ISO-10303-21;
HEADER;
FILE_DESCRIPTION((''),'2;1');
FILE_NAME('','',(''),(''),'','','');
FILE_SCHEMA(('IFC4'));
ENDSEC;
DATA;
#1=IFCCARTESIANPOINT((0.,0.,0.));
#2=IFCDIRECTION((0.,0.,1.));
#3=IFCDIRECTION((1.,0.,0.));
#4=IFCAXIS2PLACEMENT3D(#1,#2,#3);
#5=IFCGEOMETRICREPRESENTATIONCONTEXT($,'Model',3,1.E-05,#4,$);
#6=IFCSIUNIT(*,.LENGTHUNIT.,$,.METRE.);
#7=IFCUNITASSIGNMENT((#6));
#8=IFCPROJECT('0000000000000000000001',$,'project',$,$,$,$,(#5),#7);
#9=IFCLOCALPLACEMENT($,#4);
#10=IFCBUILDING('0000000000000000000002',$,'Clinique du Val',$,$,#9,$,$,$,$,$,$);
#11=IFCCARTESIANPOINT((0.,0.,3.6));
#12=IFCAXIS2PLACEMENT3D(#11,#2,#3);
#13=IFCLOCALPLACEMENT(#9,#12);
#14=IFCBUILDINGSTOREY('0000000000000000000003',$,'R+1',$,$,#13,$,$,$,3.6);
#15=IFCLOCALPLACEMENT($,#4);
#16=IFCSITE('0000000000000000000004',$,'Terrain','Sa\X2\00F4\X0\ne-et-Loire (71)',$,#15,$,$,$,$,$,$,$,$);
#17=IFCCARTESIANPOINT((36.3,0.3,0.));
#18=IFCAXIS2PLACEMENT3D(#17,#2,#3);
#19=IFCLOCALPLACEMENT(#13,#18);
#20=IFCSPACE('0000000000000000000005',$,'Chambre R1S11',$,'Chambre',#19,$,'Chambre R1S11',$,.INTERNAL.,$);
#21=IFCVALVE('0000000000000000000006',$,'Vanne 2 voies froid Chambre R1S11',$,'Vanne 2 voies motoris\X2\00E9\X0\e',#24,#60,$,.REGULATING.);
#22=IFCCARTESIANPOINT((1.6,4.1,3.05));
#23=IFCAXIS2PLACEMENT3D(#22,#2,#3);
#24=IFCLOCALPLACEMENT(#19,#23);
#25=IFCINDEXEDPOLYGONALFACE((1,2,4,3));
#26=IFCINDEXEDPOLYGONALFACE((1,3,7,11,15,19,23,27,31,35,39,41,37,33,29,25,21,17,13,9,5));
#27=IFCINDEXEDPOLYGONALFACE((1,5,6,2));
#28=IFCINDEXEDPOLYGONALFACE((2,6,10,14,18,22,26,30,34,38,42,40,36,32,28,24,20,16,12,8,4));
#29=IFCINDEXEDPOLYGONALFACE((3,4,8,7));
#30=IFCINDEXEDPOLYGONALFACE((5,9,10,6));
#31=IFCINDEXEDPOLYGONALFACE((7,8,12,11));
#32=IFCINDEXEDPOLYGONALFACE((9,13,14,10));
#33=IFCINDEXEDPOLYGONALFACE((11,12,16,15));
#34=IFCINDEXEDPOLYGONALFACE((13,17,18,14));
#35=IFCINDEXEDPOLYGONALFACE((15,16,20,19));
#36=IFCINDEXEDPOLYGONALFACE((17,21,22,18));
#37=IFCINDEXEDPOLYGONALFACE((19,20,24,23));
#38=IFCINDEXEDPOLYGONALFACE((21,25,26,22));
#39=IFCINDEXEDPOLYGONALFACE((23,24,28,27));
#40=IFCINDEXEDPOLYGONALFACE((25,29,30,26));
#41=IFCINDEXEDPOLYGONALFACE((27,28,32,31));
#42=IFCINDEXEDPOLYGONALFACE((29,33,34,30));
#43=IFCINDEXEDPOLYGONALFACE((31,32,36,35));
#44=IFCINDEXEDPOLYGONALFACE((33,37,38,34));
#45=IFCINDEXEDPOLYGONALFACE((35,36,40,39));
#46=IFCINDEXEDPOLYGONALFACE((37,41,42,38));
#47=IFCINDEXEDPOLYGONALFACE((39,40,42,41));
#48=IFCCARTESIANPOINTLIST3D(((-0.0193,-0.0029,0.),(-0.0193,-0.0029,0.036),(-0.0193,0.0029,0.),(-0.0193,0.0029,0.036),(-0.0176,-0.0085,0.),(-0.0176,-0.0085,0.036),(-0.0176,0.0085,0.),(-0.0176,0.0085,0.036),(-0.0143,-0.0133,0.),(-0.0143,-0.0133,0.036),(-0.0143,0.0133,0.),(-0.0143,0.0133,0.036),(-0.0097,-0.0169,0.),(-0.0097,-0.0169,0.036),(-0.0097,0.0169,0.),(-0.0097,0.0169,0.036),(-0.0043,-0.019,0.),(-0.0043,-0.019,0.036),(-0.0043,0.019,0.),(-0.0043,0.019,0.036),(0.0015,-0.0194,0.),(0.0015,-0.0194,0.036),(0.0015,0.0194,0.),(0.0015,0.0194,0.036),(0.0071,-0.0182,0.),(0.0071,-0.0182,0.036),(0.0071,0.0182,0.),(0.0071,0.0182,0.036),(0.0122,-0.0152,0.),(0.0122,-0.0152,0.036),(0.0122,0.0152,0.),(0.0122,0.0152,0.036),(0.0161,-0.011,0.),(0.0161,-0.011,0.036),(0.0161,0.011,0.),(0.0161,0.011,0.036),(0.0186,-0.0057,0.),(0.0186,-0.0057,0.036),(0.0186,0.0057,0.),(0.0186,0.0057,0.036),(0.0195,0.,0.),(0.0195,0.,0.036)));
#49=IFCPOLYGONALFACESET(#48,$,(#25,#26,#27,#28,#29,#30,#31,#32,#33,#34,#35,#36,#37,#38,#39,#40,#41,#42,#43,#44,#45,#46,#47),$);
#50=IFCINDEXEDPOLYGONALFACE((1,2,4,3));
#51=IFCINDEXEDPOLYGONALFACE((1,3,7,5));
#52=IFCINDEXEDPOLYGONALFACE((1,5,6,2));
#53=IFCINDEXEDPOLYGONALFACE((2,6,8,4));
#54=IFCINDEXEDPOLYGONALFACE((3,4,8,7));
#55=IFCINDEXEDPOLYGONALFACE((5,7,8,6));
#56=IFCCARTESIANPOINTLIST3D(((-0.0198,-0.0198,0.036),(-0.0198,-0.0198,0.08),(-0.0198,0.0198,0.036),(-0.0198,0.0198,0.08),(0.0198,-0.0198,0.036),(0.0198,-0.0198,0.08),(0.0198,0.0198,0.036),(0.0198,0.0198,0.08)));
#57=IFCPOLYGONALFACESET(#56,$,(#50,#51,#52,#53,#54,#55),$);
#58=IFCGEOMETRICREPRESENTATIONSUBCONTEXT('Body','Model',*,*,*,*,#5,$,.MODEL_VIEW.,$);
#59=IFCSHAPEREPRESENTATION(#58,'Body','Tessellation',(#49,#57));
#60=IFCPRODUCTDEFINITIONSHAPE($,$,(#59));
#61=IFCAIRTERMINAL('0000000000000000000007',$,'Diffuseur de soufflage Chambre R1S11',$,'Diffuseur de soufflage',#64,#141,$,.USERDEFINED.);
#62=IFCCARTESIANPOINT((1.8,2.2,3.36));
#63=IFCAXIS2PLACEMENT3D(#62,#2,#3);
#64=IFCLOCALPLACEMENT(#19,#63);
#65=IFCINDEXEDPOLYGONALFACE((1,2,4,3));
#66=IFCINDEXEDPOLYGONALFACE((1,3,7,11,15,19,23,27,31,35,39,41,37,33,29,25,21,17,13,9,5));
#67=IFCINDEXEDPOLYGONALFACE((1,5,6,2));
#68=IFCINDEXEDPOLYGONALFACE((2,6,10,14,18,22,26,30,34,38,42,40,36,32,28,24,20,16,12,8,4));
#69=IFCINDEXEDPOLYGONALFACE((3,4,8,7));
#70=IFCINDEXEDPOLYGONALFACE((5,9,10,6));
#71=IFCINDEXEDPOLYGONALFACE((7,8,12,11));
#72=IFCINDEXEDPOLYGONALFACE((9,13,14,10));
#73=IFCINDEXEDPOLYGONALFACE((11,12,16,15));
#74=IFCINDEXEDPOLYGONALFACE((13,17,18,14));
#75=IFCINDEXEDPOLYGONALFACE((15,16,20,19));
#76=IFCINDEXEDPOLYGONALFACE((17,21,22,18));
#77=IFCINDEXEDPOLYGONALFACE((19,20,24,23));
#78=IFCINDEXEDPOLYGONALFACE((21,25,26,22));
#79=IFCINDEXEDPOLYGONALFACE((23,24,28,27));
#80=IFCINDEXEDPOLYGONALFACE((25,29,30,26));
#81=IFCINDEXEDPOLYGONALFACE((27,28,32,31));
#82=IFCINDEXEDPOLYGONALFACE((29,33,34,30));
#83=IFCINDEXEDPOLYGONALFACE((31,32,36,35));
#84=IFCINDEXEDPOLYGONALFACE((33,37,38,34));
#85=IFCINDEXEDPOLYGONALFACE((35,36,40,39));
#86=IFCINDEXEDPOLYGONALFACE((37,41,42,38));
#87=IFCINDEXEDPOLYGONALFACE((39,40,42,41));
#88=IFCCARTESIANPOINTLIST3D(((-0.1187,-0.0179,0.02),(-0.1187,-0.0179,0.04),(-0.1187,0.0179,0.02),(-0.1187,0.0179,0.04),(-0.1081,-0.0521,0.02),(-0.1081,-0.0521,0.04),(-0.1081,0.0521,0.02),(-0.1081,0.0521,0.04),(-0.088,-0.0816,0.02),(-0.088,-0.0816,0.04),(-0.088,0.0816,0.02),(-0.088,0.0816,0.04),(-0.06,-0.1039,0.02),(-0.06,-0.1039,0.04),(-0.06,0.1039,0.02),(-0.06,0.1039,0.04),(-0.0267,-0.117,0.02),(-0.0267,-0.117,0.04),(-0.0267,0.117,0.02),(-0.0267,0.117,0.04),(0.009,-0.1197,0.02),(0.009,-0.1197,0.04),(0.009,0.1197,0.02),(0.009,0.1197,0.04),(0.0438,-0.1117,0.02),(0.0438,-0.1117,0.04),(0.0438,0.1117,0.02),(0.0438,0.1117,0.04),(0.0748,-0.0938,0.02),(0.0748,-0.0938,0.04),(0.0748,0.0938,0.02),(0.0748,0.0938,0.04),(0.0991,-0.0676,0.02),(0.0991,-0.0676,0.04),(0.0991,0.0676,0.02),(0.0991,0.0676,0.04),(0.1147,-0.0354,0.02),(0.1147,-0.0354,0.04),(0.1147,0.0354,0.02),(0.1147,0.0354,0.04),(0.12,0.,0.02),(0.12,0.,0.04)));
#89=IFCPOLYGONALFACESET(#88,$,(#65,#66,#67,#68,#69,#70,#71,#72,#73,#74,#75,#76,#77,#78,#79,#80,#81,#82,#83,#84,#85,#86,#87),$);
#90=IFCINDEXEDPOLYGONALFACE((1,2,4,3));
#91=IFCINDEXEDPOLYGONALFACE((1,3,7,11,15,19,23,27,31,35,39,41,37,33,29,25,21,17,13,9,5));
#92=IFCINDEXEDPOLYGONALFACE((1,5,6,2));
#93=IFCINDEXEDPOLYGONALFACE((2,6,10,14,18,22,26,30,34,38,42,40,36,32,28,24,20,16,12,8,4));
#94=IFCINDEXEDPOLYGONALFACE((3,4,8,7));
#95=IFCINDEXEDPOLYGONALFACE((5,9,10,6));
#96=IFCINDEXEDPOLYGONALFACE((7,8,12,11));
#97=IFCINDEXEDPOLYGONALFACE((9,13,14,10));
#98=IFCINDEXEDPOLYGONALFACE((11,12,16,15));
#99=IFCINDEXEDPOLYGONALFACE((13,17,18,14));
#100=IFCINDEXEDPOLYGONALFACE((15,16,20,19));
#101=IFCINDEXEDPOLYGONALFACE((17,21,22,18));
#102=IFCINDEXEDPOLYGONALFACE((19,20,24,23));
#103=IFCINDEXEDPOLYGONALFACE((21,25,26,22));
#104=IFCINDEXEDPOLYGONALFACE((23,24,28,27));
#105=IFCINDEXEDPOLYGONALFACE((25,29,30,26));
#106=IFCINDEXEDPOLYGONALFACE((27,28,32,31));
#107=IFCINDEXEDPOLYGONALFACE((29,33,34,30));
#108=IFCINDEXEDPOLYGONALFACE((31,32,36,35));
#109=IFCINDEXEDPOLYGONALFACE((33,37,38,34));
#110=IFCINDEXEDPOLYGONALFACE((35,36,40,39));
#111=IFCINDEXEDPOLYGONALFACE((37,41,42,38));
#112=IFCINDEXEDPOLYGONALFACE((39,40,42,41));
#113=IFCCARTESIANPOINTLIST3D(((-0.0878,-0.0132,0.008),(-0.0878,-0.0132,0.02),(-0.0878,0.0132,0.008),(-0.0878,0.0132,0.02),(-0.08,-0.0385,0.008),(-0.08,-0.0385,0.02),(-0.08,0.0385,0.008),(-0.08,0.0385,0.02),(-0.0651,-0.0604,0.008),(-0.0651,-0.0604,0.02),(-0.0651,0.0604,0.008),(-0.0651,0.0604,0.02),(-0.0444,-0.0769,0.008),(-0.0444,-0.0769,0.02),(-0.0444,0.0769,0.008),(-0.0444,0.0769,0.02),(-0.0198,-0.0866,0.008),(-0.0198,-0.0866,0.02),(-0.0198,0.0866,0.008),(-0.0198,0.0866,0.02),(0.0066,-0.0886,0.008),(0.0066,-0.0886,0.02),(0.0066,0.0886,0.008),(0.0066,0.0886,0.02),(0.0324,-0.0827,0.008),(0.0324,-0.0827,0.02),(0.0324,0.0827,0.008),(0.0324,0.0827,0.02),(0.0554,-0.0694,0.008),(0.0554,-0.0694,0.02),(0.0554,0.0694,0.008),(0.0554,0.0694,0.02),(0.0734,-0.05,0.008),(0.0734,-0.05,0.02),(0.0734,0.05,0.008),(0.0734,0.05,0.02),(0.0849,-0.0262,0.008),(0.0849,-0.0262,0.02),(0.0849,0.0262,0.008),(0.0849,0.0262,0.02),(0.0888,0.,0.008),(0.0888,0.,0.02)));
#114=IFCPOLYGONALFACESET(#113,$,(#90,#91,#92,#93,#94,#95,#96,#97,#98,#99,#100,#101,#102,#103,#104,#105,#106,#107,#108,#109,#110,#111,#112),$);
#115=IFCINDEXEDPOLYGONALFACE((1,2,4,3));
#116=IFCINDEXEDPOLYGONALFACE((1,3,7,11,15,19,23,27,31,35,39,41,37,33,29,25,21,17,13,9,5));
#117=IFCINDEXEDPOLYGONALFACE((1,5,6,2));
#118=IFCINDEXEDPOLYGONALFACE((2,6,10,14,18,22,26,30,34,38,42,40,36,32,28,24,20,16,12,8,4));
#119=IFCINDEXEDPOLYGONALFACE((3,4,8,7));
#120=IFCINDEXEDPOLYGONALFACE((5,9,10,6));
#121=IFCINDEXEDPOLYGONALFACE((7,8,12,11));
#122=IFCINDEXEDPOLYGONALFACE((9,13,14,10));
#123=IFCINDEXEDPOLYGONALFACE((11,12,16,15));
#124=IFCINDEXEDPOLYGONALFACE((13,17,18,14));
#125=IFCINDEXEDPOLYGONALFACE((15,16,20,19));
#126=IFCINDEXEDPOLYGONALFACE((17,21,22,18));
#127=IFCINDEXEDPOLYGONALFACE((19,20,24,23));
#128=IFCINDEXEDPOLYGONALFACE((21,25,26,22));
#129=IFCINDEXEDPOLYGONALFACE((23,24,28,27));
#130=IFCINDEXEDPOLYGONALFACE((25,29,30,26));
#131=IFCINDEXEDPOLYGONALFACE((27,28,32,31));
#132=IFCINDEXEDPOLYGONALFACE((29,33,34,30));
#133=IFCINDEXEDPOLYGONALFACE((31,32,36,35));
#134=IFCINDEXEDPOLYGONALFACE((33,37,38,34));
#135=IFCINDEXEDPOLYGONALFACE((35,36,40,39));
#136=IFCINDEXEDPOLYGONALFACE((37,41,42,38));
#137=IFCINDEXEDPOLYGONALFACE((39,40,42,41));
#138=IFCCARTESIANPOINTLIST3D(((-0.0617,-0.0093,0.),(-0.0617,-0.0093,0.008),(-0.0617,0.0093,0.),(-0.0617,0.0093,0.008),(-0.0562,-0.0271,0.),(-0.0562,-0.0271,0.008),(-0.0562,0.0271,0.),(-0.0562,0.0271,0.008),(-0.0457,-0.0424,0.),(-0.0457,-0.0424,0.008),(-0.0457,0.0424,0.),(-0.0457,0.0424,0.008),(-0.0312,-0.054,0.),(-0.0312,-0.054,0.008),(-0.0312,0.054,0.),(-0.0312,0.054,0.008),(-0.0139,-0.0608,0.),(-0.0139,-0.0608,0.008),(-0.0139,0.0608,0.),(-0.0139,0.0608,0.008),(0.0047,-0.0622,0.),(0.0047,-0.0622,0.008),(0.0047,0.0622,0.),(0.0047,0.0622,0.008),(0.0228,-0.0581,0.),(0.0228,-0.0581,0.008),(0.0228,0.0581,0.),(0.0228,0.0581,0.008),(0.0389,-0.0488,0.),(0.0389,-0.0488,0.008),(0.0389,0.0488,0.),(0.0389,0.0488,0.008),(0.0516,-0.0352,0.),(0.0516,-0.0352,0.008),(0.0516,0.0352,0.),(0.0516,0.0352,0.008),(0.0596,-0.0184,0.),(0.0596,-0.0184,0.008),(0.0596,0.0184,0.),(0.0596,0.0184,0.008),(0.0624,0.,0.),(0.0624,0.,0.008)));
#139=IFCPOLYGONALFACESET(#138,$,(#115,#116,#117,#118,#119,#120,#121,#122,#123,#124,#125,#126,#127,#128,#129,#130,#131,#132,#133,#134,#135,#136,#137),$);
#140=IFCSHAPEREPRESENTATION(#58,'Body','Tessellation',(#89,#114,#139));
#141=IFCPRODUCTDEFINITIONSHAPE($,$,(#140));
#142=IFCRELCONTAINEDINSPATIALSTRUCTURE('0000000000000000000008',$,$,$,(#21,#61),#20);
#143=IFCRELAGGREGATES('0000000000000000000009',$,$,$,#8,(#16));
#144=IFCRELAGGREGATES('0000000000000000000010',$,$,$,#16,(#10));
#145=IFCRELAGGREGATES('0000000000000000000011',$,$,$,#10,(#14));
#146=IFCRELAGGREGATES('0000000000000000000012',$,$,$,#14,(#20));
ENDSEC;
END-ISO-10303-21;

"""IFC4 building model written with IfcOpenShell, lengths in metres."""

from ifc_helpers import new_model, si_unit, frame, frame_2d, origin_with_axes, place, context, subcontext, project, spatial, rectangle, circle, extrude, element, save


model = new_model("IFC4")

# Units and contexts
model_context = context("Model", 3, precision=1e-05, world=origin_with_axes())
body_context = subcontext(model_context, "Body", "Model", "MODEL_VIEW")
ifc_project = project(units=[si_unit("LENGTHUNIT", "METRE")], contexts=[model_context])

# Site, building, storey
site_placement = place(None, origin_with_axes())
site = spatial("IfcSite", under=ifc_project, at=site_placement, Name="Terrain", Description="Saône-et-Loire (71)")
building_placement = place(None, origin_with_axes())
building = spatial("IfcBuilding", under=site, at=building_placement, Name="Clinique du Val")
storey_placement = place(building_placement, frame((0.0, 0.0, 3.6), z_axis=(0.0, 0.0, 1.0), x_axis=(1.0, 0.0, 0.0)))
storey = spatial("IfcBuildingStorey", under=building, at=storey_placement, Name="R+1", Elevation=3.6)

# Shared definitions
space_1_placement = place(storey_placement, frame((36.3, 0.3, 0.0), z_axis=(0.0, 0.0, 1.0), x_axis=(1.0, 0.0, 0.0)))
space_1 = spatial("IfcSpace", under=storey, at=space_1_placement, Name="Chambre R1S11", ObjectType="Chambre", LongName="Chambre R1S11", PredefinedType="INTERNAL")

# Valve
for number, where, z_axis, x_axis, name in (
    (1, (1.6, 4.1, 3.05), (0.0, 0.0, 1.0), (1.0, 0.0, 0.0), "Vanne 2 voies froid Chambre R1S11"),
):
    element("IfcValve", number, at=place(space_1_placement, frame(where, z_axis=z_axis, x_axis=x_axis)), inside=space_1, Name=name, ObjectType="Vanne 2 voies motorisée", PredefinedType="REGULATING", context=body_context, shape_type="SweptSolid", body=[
        extrude(circle(Radius=0.0195), origin_with_axes(), (0.0, 0.0, 1.0), 0.036),
        extrude(rectangle(XDim=0.0396, YDim=0.0396, at=frame_2d((0.0198, 0.0198))), frame((-0.0198, -0.0198, 0.036), z_axis=(0.0, 0.0, 1.0), x_axis=(1.0, 0.0, 0.0)), (0.0, 0.0, 1.0), 0.044),
    ])

# Air terminal
air_terminal_1_placement = place(space_1_placement, frame((1.8, 2.2, 3.36), z_axis=(0.0, 0.0, 1.0), x_axis=(1.0, 0.0, 0.0)))
element("IfcAirTerminal", 2, at=air_terminal_1_placement, inside=space_1, Name="Diffuseur de soufflage Chambre R1S11", ObjectType="Diffuseur de soufflage", PredefinedType="USERDEFINED", context=body_context, shape_type="SweptSolid", body=[
    extrude(circle(Radius=0.12), frame((0.0, 0.0, 0.02), z_axis=(0.0, 0.0, 1.0), x_axis=(1.0, 0.0, 0.0)), (0.0, 0.0, 1.0), 0.02),
    extrude(circle(Radius=0.0888), frame((0.0, 0.0, 0.008), z_axis=(0.0, 0.0, 1.0), x_axis=(1.0, 0.0, 0.0)), (0.0, 0.0, 1.0), 0.012),
    extrude(circle(Radius=0.0624), origin_with_axes(), (0.0, 0.0, 1.0), 0.008),
])

save(model, "model.ifc")
